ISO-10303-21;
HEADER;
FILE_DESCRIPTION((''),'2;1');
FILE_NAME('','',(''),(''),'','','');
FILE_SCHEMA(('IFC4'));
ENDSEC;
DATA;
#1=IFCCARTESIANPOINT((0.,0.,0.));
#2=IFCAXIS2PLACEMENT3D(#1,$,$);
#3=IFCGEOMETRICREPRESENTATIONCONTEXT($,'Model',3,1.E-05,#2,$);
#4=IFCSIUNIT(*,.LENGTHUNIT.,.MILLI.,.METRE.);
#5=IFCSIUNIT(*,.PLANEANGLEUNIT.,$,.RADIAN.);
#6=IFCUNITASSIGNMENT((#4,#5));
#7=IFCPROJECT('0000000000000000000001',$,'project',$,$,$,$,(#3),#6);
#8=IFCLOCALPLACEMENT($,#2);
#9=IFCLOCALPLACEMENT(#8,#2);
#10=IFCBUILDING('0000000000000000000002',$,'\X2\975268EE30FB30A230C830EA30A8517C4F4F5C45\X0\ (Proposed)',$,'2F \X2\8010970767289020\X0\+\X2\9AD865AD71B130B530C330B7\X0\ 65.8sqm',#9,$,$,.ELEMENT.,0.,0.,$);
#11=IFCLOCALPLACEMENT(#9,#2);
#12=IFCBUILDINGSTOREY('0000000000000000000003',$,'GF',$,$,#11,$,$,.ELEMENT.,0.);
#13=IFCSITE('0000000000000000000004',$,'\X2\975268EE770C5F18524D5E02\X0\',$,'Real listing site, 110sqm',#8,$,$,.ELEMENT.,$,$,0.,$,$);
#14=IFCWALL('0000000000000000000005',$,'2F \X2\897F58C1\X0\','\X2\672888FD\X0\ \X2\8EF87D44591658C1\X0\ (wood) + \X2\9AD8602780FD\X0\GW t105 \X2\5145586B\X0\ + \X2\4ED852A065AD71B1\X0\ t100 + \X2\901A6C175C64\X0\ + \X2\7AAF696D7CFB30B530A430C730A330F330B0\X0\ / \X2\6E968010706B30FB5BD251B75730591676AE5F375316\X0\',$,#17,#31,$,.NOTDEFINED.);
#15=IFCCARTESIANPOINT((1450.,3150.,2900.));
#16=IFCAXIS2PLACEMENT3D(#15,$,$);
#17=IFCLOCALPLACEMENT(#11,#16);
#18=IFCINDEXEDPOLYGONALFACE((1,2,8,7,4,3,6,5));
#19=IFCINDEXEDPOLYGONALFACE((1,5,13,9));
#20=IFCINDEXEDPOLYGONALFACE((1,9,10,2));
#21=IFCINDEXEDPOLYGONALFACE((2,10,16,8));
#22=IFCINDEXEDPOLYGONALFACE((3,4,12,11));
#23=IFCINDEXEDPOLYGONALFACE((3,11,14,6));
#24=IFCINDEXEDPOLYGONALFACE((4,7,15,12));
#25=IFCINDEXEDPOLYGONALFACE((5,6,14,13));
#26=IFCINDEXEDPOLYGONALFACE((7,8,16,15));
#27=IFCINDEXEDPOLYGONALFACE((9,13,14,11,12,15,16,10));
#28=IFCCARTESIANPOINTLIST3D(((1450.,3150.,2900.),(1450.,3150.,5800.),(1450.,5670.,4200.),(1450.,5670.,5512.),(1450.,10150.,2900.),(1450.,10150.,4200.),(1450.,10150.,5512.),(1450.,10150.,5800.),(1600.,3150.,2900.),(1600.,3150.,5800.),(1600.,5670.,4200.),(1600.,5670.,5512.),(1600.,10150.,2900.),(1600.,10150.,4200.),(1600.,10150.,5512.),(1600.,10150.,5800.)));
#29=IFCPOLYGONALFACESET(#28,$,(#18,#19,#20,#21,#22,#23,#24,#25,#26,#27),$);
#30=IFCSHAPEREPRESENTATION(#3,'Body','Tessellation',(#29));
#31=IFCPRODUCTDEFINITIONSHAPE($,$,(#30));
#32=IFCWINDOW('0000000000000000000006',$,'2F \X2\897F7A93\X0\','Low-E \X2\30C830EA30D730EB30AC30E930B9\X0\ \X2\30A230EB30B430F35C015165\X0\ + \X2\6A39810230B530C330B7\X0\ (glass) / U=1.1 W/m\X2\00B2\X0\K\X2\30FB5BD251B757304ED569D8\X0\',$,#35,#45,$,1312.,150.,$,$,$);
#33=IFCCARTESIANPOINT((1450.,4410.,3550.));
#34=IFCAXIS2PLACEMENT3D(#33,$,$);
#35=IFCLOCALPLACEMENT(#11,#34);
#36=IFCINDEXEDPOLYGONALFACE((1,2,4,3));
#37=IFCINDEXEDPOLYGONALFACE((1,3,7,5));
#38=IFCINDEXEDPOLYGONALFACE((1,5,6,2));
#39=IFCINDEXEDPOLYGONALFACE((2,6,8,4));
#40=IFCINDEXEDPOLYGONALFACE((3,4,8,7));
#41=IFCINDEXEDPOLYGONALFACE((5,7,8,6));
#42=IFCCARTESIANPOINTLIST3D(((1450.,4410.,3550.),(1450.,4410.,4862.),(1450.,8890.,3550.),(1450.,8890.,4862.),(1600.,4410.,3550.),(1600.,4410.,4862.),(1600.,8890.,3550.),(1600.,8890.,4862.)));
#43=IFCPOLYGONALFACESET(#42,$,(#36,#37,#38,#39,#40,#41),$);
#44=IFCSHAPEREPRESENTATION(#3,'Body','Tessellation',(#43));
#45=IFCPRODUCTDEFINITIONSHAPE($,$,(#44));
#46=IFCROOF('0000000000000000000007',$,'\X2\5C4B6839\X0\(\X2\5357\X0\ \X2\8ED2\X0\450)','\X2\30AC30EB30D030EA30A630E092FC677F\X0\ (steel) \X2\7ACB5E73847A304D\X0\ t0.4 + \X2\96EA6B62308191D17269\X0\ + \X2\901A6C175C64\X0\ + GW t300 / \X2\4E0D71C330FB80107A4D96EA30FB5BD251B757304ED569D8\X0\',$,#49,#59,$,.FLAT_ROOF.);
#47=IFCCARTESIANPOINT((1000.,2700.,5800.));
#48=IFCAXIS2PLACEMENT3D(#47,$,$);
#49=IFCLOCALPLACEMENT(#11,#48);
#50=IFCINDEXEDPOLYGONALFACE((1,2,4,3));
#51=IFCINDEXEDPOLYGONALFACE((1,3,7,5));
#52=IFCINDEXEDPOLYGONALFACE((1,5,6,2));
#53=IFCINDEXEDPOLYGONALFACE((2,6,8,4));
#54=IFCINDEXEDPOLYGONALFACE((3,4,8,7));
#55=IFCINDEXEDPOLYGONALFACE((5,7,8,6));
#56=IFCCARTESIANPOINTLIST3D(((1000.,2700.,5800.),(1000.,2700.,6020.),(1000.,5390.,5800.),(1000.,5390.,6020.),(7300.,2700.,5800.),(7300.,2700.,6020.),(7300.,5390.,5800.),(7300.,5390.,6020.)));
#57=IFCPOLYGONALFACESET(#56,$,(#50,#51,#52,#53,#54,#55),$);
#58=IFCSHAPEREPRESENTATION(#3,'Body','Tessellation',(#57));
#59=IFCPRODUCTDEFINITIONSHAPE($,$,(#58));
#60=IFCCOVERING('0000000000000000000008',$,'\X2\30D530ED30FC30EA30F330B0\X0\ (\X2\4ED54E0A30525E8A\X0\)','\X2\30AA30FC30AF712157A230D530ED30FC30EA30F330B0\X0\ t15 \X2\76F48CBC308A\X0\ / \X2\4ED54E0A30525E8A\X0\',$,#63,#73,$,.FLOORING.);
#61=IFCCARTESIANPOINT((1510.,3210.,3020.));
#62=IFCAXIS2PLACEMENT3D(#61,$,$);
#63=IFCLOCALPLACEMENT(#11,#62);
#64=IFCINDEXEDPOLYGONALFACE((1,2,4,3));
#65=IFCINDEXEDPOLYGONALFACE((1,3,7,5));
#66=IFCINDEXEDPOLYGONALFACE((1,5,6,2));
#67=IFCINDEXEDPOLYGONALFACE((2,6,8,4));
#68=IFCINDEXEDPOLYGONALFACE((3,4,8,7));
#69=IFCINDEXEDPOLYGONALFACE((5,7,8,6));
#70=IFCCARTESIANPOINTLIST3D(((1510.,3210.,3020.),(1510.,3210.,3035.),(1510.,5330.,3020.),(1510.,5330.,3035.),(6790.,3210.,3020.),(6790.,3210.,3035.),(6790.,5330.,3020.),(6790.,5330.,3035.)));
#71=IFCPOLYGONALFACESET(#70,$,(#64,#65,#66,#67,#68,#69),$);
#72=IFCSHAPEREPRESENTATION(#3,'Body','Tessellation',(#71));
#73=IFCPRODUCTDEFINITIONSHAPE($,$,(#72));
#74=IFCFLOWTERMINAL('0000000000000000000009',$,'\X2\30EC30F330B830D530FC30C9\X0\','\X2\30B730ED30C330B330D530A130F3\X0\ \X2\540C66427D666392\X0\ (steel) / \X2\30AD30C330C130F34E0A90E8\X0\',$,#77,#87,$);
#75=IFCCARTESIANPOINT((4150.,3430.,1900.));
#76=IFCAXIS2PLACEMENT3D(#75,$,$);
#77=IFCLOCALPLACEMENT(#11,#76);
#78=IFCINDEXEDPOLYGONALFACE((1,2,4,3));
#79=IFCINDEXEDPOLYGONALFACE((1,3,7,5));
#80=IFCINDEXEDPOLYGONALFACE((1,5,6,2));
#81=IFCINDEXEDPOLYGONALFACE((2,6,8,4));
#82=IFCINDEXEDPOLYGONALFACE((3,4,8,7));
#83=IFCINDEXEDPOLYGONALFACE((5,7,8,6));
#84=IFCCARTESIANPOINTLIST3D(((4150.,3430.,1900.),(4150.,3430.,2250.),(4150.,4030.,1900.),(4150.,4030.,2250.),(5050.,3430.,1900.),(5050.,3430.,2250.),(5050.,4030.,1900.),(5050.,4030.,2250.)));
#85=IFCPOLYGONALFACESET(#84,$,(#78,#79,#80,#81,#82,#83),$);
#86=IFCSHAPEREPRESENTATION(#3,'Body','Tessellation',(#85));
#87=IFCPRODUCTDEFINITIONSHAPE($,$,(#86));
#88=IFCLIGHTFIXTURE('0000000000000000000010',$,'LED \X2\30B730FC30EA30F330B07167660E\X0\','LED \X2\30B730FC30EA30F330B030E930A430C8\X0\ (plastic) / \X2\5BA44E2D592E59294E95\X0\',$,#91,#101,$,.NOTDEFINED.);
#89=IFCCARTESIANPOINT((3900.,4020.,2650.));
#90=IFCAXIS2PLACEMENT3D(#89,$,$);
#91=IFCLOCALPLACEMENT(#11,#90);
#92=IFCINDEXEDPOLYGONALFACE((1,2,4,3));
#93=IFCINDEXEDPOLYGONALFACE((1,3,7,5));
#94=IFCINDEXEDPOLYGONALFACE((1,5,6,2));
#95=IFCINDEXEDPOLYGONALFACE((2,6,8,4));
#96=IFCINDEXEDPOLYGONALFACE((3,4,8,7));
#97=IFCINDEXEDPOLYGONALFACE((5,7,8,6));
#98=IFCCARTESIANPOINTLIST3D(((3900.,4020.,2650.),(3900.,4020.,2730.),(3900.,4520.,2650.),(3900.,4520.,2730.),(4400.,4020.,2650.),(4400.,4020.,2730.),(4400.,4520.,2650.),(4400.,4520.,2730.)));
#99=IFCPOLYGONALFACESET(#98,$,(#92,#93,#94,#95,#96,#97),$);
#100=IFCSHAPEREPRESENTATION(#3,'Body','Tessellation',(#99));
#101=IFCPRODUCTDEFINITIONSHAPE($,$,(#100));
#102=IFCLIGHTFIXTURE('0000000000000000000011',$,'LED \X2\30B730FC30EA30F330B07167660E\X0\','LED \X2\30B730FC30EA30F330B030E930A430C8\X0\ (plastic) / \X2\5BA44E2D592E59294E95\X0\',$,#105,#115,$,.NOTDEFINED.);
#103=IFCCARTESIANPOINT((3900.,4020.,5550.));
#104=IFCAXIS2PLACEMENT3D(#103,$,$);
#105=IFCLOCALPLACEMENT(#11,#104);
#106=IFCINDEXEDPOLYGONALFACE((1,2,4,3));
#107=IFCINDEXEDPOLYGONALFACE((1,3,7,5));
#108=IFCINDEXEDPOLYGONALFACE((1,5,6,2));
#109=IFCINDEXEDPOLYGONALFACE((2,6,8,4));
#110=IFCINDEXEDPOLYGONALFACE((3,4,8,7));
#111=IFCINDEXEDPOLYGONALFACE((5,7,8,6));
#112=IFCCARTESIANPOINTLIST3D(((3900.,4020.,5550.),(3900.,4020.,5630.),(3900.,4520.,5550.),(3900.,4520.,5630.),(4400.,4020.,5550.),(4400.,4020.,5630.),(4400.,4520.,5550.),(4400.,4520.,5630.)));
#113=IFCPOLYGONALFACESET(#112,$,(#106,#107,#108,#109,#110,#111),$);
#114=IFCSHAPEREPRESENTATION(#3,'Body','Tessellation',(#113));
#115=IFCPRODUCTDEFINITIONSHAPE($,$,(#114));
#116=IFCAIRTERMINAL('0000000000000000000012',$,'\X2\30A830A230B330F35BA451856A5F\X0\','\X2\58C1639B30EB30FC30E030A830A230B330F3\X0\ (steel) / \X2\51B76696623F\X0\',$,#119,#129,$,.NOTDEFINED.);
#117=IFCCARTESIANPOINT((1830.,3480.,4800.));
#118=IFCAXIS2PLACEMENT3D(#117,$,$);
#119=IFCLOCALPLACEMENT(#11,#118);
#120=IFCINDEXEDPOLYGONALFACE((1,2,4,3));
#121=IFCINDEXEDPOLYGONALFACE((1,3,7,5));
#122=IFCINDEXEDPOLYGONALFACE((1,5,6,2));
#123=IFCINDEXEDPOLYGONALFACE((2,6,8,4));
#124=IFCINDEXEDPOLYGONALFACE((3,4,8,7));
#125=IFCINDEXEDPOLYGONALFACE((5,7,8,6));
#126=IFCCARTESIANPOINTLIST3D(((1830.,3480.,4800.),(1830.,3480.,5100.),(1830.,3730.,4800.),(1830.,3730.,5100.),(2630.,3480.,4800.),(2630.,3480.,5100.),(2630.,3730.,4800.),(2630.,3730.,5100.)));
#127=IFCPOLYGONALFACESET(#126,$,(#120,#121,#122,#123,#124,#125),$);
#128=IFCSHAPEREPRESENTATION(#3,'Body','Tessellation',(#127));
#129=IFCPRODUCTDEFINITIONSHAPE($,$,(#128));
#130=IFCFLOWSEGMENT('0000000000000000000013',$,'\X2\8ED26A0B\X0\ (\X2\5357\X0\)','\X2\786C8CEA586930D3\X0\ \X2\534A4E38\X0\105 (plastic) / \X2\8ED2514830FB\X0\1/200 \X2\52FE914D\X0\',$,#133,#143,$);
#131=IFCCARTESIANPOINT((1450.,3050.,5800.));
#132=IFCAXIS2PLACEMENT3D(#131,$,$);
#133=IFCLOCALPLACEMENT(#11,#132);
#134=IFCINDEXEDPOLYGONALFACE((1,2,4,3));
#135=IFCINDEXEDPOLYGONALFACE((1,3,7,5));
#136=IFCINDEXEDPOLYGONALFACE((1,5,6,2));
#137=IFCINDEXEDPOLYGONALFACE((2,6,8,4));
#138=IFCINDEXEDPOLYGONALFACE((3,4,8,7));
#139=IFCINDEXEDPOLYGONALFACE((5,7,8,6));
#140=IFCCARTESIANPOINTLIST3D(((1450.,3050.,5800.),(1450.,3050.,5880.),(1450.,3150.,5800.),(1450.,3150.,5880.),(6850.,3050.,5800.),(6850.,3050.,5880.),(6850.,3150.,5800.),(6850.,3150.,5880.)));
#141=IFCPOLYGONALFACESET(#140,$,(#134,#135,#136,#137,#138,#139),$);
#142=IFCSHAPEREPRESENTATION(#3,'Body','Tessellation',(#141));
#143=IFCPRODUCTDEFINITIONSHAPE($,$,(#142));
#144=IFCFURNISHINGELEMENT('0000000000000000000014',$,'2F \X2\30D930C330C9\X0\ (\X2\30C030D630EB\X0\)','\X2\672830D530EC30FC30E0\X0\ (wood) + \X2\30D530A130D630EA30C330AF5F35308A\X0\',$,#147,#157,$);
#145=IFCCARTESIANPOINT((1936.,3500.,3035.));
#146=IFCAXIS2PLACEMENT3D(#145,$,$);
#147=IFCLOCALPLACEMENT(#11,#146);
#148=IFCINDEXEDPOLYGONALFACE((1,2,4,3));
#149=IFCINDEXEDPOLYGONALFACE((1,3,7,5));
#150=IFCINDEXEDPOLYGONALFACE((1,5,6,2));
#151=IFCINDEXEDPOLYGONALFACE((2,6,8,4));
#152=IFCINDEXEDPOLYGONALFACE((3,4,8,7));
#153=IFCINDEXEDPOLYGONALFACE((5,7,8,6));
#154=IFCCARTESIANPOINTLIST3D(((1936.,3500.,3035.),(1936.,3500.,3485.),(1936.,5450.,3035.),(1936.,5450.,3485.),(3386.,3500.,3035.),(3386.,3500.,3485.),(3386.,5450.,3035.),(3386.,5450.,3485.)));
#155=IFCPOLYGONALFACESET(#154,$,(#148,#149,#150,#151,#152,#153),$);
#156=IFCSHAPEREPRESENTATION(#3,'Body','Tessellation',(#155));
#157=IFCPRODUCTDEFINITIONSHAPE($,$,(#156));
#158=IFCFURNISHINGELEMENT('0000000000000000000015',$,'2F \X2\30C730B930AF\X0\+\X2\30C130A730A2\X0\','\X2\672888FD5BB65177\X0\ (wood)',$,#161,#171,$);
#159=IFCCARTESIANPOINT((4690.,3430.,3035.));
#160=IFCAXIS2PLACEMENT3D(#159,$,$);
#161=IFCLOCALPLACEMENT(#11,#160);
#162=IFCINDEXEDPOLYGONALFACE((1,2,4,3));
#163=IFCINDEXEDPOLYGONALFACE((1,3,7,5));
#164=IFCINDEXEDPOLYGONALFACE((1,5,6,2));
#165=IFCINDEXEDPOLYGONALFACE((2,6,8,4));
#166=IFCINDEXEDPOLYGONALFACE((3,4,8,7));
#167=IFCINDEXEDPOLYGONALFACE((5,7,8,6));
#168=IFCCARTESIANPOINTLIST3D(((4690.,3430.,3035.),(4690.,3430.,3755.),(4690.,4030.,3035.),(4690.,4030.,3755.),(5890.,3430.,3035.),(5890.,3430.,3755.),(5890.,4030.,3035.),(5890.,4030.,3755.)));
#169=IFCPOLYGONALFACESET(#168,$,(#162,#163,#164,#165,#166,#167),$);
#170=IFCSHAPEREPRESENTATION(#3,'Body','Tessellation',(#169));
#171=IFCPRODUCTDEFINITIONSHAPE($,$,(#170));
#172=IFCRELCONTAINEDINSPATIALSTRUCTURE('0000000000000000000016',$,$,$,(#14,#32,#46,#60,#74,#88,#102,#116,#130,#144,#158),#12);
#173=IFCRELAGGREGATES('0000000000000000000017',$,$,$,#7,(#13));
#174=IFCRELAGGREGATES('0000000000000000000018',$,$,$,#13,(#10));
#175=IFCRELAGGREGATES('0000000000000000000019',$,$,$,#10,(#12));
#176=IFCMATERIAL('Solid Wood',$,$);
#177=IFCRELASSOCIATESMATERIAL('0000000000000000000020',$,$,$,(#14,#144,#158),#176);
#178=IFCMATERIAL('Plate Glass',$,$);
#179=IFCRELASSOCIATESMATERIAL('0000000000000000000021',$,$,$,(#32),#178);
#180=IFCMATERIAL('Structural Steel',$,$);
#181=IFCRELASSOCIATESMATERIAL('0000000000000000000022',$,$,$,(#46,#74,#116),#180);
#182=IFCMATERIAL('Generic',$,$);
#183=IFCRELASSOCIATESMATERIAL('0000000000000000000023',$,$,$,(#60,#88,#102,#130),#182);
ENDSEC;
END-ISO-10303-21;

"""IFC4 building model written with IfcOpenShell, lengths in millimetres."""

from ifc_helpers import new_model, si_unit, frame, frame_2d, origin, place, context, project, spatial, rectangle, extrude, material, element, fill, save


model = new_model("IFC4")

# Units and contexts
model_context = context("Model", 3, precision=1e-05, world=origin())
ifc_project = project(units=[si_unit("LENGTHUNIT", "METRE", prefix="MILLI"), si_unit("PLANEANGLEUNIT", "RADIAN")], contexts=[model_context])

# Site, building, storey
site_placement = place(None, origin())
site = spatial("IfcSite", under=ifc_project, at=site_placement, Name="青森県弘前市", ObjectType="Real listing site, 110sqm", CompositionType="ELEMENT", RefElevation=0.0)
building_placement = place(site_placement, origin())
building = spatial("IfcBuilding", under=site, at=building_placement, Name="青森・アトリエ兼住居 (Proposed)", ObjectType="2F 耐震木造+高断熱サッシ 65.8sqm", CompositionType="ELEMENT", ElevationOfRefHeight=0.0, ElevationOfTerrain=0.0)
storey_placement = place(building_placement, origin())
storey = spatial("IfcBuildingStorey", under=building, at=storey_placement, Name="GF", CompositionType="ELEMENT", Elevation=0.0)

# Shared definitions
ifc_material_1 = material(Name="Solid Wood")

# Shared definitions
ifc_material_2 = material(Name="Plate Glass")

# Wall, opening, window
wall_1_placement = place(storey_placement, frame((1450.0, 3150.0, 2900.0)))
wall_1 = element("IfcWall", 1, at=wall_1_placement, inside=storey, material=ifc_material_1, Name="2F 西壁", Description="木製 軸組外壁 (wood) + 高性能GW t105 充填 + 付加断熱 t100 + 通気層 + 窯業系サイディング / 準耐火・寒冷地外皮強化", PredefinedType="NOTDEFINED", context=model_context, shape_type="SweptSolid", body=[
    extrude(rectangle(XDim=150.0, YDim=7000.0, at=frame_2d((75.0, 3500.0))), frame((1450.0, 3150.0, 2900.0)), (0.0, 0.0, 1.0), 2900.0),
])
opening_1_placement = place(storey_placement, frame((1450.0, 4410.0, 3550.0)))
opening_1 = element("IfcOpeningElement", 2, at=opening_1_placement, cuts=wall_1, PredefinedType="NOTDEFINED", context=model_context, shape_type="SweptSolid", body=[
    extrude(rectangle(XDim=150.0, YDim=4480.0, at=frame_2d((75.0, 2240.0))), frame((1450.0, 4410.0, 3550.0)), (0.0, 0.0, 1.0), 1312.0),
])
window_1_placement = place(storey_placement, frame((1450.0, 4410.0, 3550.0)))
window_1 = element("IfcWindow", 3, at=window_1_placement, inside=storey, material=ifc_material_2, Name="2F 西窓", Description="Low-E トリプルガラス アルゴン封入 + 樹脂サッシ (glass) / U=1.1 W/m²K・寒冷地仕様", OverallHeight=1312.0, OverallWidth=150.0, context=model_context, shape_type="SweptSolid", body=[
    extrude(rectangle(XDim=150.0, YDim=4480.0, at=frame_2d((75.0, 2240.0))), frame((1450.0, 4410.0, 3550.0)), (0.0, 0.0, 1.0), 1312.0),
])
fill(opening_1, window_1)

# Roof
ifc_material_3 = material(Name="Structural Steel")
for number, where, name in (
    (4, (1000.0, 2700.0, 5800.0), "屋根(南 軒450)"),
):
    element("IfcRoof", number, at=place(storey_placement, frame(where)), inside=storey, material=ifc_material_3, Name=name, Description="ガルバリウム鋼板 (steel) 立平葺き t0.4 + 雪止め金物 + 通気層 + GW t300 / 不燃・耐積雪・寒冷地仕様", PredefinedType="FLAT_ROOF", context=model_context, shape_type="SweptSolid", body=[
        extrude(rectangle(XDim=6300.0, YDim=2690.0, at=frame_2d((3150.0, 1345.0))), frame((1000.0, 2700.0, 5800.0)), (0.0, 0.0, 1.0), 220.0),
    ])

# Covering
ifc_material_4 = material(Name="Generic")
covering_placement = place(storey_placement, frame((1510.0, 3210.0, 3020.0)))
element("IfcCovering", 5, at=covering_placement, inside=storey, material=ifc_material_4, Name="フローリング (仕上げ床)", Description="オーク無垢フローリング t15 直貼り / 仕上げ床", PredefinedType="FLOORING", context=model_context, shape_type="SweptSolid", body=[
    extrude(rectangle(XDim=5280.0, YDim=2120.0, at=frame_2d((2640.0, 1060.0))), frame((1510.0, 3210.0, 3020.0)), (0.0, 0.0, 1.0), 15.0),
])

# Flow terminal
flow_terminal_placement = place(storey_placement, frame((4150.0, 3430.0, 1900.0)))
element("IfcFlowTerminal", 6, at=flow_terminal_placement, inside=storey, material=ifc_material_3, Name="レンジフード", Description="シロッコファン 同時給排 (steel) / キッチン上部", context=model_context, shape_type="SweptSolid", body=[
    extrude(rectangle(XDim=900.0, YDim=600.0, at=frame_2d((450.0, 300.0))), frame((4150.0, 3430.0, 1900.0)), (0.0, 0.0, 1.0), 350.0),
])

# Light fixtures
light_fixture_1_placement = place(storey_placement, frame((3900.0, 4020.0, 2650.0)))
element("IfcLightFixture", 7, at=light_fixture_1_placement, inside=storey, material=ifc_material_4, Name="LED シーリング照明", Description="LED シーリングライト (plastic) / 室中央天井", PredefinedType="NOTDEFINED", context=model_context, shape_type="SweptSolid", body=[
    extrude(rectangle(XDim=500.0, YDim=500.0, at=frame_2d((250.0, 250.0))), frame((3900.0, 4020.0, 2650.0)), (0.0, 0.0, 1.0), 80.0),
])
light_fixture_2_placement = place(storey_placement, frame((3900.0, 4020.0, 5550.0)))
element("IfcLightFixture", 8, at=light_fixture_2_placement, inside=storey, material=ifc_material_4, Name="LED シーリング照明", Description="LED シーリングライト (plastic) / 室中央天井", PredefinedType="NOTDEFINED", context=model_context, shape_type="SweptSolid", body=[
    extrude(rectangle(XDim=500.0, YDim=500.0, at=frame_2d((250.0, 250.0))), frame((3900.0, 4020.0, 5550.0)), (0.0, 0.0, 1.0), 80.0),
])

# Air terminal
air_terminal_placement = place(storey_placement, frame((1830.0, 3480.0, 4800.0)))
element("IfcAirTerminal", 9, at=air_terminal_placement, inside=storey, material=ifc_material_3, Name="エアコン室内機", Description="壁掛ルームエアコン (steel) / 冷暖房", PredefinedType="NOTDEFINED", context=model_context, shape_type="SweptSolid", body=[
    extrude(rectangle(XDim=800.0, YDim=250.0, at=frame_2d((400.0, 125.0))), frame((1830.0, 3480.0, 4800.0)), (0.0, 0.0, 1.0), 300.0),
])

# Flow segment
flow_segment_placement = place(storey_placement, frame((1450.0, 3050.0, 5800.0)))
element("IfcFlowSegment", 10, at=flow_segment_placement, inside=storey, material=ifc_material_4, Name="軒樋 (南)", Description="硬質塩ビ 半丸105 (plastic) / 軒先・1/200 勾配", context=model_context, shape_type="SweptSolid", body=[
    extrude(rectangle(XDim=5400.0, YDim=100.0, at=frame_2d((2700.0, 50.0))), frame((1450.0, 3050.0, 5800.0)), (0.0, 0.0, 1.0), 80.0),
])

# Furnishing elements
furnishing_1_placement = place(storey_placement, frame((1936.0, 3500.0, 3035.0)))
element("IfcFurnishingElement", 11, at=furnishing_1_placement, inside=storey, material=ifc_material_1, Name="2F ベッド (ダブル)", Description="木フレーム (wood) + ファブリック張り", context=model_context, shape_type="SweptSolid", body=[
    extrude(rectangle(XDim=1450.0, YDim=1950.0, at=frame_2d((725.0, 975.0))), frame((1936.0, 3500.0, 3035.0)), (0.0, 0.0, 1.0), 450.0),
])
furnishing_2_placement = place(storey_placement, frame((4690.0, 3430.0, 3035.0)))
element("IfcFurnishingElement", 12, at=furnishing_2_placement, inside=storey, material=ifc_material_1, Name="2F デスク+チェア", Description="木製家具 (wood)", context=model_context, shape_type="SweptSolid", body=[
    extrude(rectangle(XDim=1200.0, YDim=600.0, at=frame_2d((600.0, 300.0))), frame((4690.0, 3430.0, 3035.0)), (0.0, 0.0, 1.0), 720.0),
])

save(model, "model.ifc")
